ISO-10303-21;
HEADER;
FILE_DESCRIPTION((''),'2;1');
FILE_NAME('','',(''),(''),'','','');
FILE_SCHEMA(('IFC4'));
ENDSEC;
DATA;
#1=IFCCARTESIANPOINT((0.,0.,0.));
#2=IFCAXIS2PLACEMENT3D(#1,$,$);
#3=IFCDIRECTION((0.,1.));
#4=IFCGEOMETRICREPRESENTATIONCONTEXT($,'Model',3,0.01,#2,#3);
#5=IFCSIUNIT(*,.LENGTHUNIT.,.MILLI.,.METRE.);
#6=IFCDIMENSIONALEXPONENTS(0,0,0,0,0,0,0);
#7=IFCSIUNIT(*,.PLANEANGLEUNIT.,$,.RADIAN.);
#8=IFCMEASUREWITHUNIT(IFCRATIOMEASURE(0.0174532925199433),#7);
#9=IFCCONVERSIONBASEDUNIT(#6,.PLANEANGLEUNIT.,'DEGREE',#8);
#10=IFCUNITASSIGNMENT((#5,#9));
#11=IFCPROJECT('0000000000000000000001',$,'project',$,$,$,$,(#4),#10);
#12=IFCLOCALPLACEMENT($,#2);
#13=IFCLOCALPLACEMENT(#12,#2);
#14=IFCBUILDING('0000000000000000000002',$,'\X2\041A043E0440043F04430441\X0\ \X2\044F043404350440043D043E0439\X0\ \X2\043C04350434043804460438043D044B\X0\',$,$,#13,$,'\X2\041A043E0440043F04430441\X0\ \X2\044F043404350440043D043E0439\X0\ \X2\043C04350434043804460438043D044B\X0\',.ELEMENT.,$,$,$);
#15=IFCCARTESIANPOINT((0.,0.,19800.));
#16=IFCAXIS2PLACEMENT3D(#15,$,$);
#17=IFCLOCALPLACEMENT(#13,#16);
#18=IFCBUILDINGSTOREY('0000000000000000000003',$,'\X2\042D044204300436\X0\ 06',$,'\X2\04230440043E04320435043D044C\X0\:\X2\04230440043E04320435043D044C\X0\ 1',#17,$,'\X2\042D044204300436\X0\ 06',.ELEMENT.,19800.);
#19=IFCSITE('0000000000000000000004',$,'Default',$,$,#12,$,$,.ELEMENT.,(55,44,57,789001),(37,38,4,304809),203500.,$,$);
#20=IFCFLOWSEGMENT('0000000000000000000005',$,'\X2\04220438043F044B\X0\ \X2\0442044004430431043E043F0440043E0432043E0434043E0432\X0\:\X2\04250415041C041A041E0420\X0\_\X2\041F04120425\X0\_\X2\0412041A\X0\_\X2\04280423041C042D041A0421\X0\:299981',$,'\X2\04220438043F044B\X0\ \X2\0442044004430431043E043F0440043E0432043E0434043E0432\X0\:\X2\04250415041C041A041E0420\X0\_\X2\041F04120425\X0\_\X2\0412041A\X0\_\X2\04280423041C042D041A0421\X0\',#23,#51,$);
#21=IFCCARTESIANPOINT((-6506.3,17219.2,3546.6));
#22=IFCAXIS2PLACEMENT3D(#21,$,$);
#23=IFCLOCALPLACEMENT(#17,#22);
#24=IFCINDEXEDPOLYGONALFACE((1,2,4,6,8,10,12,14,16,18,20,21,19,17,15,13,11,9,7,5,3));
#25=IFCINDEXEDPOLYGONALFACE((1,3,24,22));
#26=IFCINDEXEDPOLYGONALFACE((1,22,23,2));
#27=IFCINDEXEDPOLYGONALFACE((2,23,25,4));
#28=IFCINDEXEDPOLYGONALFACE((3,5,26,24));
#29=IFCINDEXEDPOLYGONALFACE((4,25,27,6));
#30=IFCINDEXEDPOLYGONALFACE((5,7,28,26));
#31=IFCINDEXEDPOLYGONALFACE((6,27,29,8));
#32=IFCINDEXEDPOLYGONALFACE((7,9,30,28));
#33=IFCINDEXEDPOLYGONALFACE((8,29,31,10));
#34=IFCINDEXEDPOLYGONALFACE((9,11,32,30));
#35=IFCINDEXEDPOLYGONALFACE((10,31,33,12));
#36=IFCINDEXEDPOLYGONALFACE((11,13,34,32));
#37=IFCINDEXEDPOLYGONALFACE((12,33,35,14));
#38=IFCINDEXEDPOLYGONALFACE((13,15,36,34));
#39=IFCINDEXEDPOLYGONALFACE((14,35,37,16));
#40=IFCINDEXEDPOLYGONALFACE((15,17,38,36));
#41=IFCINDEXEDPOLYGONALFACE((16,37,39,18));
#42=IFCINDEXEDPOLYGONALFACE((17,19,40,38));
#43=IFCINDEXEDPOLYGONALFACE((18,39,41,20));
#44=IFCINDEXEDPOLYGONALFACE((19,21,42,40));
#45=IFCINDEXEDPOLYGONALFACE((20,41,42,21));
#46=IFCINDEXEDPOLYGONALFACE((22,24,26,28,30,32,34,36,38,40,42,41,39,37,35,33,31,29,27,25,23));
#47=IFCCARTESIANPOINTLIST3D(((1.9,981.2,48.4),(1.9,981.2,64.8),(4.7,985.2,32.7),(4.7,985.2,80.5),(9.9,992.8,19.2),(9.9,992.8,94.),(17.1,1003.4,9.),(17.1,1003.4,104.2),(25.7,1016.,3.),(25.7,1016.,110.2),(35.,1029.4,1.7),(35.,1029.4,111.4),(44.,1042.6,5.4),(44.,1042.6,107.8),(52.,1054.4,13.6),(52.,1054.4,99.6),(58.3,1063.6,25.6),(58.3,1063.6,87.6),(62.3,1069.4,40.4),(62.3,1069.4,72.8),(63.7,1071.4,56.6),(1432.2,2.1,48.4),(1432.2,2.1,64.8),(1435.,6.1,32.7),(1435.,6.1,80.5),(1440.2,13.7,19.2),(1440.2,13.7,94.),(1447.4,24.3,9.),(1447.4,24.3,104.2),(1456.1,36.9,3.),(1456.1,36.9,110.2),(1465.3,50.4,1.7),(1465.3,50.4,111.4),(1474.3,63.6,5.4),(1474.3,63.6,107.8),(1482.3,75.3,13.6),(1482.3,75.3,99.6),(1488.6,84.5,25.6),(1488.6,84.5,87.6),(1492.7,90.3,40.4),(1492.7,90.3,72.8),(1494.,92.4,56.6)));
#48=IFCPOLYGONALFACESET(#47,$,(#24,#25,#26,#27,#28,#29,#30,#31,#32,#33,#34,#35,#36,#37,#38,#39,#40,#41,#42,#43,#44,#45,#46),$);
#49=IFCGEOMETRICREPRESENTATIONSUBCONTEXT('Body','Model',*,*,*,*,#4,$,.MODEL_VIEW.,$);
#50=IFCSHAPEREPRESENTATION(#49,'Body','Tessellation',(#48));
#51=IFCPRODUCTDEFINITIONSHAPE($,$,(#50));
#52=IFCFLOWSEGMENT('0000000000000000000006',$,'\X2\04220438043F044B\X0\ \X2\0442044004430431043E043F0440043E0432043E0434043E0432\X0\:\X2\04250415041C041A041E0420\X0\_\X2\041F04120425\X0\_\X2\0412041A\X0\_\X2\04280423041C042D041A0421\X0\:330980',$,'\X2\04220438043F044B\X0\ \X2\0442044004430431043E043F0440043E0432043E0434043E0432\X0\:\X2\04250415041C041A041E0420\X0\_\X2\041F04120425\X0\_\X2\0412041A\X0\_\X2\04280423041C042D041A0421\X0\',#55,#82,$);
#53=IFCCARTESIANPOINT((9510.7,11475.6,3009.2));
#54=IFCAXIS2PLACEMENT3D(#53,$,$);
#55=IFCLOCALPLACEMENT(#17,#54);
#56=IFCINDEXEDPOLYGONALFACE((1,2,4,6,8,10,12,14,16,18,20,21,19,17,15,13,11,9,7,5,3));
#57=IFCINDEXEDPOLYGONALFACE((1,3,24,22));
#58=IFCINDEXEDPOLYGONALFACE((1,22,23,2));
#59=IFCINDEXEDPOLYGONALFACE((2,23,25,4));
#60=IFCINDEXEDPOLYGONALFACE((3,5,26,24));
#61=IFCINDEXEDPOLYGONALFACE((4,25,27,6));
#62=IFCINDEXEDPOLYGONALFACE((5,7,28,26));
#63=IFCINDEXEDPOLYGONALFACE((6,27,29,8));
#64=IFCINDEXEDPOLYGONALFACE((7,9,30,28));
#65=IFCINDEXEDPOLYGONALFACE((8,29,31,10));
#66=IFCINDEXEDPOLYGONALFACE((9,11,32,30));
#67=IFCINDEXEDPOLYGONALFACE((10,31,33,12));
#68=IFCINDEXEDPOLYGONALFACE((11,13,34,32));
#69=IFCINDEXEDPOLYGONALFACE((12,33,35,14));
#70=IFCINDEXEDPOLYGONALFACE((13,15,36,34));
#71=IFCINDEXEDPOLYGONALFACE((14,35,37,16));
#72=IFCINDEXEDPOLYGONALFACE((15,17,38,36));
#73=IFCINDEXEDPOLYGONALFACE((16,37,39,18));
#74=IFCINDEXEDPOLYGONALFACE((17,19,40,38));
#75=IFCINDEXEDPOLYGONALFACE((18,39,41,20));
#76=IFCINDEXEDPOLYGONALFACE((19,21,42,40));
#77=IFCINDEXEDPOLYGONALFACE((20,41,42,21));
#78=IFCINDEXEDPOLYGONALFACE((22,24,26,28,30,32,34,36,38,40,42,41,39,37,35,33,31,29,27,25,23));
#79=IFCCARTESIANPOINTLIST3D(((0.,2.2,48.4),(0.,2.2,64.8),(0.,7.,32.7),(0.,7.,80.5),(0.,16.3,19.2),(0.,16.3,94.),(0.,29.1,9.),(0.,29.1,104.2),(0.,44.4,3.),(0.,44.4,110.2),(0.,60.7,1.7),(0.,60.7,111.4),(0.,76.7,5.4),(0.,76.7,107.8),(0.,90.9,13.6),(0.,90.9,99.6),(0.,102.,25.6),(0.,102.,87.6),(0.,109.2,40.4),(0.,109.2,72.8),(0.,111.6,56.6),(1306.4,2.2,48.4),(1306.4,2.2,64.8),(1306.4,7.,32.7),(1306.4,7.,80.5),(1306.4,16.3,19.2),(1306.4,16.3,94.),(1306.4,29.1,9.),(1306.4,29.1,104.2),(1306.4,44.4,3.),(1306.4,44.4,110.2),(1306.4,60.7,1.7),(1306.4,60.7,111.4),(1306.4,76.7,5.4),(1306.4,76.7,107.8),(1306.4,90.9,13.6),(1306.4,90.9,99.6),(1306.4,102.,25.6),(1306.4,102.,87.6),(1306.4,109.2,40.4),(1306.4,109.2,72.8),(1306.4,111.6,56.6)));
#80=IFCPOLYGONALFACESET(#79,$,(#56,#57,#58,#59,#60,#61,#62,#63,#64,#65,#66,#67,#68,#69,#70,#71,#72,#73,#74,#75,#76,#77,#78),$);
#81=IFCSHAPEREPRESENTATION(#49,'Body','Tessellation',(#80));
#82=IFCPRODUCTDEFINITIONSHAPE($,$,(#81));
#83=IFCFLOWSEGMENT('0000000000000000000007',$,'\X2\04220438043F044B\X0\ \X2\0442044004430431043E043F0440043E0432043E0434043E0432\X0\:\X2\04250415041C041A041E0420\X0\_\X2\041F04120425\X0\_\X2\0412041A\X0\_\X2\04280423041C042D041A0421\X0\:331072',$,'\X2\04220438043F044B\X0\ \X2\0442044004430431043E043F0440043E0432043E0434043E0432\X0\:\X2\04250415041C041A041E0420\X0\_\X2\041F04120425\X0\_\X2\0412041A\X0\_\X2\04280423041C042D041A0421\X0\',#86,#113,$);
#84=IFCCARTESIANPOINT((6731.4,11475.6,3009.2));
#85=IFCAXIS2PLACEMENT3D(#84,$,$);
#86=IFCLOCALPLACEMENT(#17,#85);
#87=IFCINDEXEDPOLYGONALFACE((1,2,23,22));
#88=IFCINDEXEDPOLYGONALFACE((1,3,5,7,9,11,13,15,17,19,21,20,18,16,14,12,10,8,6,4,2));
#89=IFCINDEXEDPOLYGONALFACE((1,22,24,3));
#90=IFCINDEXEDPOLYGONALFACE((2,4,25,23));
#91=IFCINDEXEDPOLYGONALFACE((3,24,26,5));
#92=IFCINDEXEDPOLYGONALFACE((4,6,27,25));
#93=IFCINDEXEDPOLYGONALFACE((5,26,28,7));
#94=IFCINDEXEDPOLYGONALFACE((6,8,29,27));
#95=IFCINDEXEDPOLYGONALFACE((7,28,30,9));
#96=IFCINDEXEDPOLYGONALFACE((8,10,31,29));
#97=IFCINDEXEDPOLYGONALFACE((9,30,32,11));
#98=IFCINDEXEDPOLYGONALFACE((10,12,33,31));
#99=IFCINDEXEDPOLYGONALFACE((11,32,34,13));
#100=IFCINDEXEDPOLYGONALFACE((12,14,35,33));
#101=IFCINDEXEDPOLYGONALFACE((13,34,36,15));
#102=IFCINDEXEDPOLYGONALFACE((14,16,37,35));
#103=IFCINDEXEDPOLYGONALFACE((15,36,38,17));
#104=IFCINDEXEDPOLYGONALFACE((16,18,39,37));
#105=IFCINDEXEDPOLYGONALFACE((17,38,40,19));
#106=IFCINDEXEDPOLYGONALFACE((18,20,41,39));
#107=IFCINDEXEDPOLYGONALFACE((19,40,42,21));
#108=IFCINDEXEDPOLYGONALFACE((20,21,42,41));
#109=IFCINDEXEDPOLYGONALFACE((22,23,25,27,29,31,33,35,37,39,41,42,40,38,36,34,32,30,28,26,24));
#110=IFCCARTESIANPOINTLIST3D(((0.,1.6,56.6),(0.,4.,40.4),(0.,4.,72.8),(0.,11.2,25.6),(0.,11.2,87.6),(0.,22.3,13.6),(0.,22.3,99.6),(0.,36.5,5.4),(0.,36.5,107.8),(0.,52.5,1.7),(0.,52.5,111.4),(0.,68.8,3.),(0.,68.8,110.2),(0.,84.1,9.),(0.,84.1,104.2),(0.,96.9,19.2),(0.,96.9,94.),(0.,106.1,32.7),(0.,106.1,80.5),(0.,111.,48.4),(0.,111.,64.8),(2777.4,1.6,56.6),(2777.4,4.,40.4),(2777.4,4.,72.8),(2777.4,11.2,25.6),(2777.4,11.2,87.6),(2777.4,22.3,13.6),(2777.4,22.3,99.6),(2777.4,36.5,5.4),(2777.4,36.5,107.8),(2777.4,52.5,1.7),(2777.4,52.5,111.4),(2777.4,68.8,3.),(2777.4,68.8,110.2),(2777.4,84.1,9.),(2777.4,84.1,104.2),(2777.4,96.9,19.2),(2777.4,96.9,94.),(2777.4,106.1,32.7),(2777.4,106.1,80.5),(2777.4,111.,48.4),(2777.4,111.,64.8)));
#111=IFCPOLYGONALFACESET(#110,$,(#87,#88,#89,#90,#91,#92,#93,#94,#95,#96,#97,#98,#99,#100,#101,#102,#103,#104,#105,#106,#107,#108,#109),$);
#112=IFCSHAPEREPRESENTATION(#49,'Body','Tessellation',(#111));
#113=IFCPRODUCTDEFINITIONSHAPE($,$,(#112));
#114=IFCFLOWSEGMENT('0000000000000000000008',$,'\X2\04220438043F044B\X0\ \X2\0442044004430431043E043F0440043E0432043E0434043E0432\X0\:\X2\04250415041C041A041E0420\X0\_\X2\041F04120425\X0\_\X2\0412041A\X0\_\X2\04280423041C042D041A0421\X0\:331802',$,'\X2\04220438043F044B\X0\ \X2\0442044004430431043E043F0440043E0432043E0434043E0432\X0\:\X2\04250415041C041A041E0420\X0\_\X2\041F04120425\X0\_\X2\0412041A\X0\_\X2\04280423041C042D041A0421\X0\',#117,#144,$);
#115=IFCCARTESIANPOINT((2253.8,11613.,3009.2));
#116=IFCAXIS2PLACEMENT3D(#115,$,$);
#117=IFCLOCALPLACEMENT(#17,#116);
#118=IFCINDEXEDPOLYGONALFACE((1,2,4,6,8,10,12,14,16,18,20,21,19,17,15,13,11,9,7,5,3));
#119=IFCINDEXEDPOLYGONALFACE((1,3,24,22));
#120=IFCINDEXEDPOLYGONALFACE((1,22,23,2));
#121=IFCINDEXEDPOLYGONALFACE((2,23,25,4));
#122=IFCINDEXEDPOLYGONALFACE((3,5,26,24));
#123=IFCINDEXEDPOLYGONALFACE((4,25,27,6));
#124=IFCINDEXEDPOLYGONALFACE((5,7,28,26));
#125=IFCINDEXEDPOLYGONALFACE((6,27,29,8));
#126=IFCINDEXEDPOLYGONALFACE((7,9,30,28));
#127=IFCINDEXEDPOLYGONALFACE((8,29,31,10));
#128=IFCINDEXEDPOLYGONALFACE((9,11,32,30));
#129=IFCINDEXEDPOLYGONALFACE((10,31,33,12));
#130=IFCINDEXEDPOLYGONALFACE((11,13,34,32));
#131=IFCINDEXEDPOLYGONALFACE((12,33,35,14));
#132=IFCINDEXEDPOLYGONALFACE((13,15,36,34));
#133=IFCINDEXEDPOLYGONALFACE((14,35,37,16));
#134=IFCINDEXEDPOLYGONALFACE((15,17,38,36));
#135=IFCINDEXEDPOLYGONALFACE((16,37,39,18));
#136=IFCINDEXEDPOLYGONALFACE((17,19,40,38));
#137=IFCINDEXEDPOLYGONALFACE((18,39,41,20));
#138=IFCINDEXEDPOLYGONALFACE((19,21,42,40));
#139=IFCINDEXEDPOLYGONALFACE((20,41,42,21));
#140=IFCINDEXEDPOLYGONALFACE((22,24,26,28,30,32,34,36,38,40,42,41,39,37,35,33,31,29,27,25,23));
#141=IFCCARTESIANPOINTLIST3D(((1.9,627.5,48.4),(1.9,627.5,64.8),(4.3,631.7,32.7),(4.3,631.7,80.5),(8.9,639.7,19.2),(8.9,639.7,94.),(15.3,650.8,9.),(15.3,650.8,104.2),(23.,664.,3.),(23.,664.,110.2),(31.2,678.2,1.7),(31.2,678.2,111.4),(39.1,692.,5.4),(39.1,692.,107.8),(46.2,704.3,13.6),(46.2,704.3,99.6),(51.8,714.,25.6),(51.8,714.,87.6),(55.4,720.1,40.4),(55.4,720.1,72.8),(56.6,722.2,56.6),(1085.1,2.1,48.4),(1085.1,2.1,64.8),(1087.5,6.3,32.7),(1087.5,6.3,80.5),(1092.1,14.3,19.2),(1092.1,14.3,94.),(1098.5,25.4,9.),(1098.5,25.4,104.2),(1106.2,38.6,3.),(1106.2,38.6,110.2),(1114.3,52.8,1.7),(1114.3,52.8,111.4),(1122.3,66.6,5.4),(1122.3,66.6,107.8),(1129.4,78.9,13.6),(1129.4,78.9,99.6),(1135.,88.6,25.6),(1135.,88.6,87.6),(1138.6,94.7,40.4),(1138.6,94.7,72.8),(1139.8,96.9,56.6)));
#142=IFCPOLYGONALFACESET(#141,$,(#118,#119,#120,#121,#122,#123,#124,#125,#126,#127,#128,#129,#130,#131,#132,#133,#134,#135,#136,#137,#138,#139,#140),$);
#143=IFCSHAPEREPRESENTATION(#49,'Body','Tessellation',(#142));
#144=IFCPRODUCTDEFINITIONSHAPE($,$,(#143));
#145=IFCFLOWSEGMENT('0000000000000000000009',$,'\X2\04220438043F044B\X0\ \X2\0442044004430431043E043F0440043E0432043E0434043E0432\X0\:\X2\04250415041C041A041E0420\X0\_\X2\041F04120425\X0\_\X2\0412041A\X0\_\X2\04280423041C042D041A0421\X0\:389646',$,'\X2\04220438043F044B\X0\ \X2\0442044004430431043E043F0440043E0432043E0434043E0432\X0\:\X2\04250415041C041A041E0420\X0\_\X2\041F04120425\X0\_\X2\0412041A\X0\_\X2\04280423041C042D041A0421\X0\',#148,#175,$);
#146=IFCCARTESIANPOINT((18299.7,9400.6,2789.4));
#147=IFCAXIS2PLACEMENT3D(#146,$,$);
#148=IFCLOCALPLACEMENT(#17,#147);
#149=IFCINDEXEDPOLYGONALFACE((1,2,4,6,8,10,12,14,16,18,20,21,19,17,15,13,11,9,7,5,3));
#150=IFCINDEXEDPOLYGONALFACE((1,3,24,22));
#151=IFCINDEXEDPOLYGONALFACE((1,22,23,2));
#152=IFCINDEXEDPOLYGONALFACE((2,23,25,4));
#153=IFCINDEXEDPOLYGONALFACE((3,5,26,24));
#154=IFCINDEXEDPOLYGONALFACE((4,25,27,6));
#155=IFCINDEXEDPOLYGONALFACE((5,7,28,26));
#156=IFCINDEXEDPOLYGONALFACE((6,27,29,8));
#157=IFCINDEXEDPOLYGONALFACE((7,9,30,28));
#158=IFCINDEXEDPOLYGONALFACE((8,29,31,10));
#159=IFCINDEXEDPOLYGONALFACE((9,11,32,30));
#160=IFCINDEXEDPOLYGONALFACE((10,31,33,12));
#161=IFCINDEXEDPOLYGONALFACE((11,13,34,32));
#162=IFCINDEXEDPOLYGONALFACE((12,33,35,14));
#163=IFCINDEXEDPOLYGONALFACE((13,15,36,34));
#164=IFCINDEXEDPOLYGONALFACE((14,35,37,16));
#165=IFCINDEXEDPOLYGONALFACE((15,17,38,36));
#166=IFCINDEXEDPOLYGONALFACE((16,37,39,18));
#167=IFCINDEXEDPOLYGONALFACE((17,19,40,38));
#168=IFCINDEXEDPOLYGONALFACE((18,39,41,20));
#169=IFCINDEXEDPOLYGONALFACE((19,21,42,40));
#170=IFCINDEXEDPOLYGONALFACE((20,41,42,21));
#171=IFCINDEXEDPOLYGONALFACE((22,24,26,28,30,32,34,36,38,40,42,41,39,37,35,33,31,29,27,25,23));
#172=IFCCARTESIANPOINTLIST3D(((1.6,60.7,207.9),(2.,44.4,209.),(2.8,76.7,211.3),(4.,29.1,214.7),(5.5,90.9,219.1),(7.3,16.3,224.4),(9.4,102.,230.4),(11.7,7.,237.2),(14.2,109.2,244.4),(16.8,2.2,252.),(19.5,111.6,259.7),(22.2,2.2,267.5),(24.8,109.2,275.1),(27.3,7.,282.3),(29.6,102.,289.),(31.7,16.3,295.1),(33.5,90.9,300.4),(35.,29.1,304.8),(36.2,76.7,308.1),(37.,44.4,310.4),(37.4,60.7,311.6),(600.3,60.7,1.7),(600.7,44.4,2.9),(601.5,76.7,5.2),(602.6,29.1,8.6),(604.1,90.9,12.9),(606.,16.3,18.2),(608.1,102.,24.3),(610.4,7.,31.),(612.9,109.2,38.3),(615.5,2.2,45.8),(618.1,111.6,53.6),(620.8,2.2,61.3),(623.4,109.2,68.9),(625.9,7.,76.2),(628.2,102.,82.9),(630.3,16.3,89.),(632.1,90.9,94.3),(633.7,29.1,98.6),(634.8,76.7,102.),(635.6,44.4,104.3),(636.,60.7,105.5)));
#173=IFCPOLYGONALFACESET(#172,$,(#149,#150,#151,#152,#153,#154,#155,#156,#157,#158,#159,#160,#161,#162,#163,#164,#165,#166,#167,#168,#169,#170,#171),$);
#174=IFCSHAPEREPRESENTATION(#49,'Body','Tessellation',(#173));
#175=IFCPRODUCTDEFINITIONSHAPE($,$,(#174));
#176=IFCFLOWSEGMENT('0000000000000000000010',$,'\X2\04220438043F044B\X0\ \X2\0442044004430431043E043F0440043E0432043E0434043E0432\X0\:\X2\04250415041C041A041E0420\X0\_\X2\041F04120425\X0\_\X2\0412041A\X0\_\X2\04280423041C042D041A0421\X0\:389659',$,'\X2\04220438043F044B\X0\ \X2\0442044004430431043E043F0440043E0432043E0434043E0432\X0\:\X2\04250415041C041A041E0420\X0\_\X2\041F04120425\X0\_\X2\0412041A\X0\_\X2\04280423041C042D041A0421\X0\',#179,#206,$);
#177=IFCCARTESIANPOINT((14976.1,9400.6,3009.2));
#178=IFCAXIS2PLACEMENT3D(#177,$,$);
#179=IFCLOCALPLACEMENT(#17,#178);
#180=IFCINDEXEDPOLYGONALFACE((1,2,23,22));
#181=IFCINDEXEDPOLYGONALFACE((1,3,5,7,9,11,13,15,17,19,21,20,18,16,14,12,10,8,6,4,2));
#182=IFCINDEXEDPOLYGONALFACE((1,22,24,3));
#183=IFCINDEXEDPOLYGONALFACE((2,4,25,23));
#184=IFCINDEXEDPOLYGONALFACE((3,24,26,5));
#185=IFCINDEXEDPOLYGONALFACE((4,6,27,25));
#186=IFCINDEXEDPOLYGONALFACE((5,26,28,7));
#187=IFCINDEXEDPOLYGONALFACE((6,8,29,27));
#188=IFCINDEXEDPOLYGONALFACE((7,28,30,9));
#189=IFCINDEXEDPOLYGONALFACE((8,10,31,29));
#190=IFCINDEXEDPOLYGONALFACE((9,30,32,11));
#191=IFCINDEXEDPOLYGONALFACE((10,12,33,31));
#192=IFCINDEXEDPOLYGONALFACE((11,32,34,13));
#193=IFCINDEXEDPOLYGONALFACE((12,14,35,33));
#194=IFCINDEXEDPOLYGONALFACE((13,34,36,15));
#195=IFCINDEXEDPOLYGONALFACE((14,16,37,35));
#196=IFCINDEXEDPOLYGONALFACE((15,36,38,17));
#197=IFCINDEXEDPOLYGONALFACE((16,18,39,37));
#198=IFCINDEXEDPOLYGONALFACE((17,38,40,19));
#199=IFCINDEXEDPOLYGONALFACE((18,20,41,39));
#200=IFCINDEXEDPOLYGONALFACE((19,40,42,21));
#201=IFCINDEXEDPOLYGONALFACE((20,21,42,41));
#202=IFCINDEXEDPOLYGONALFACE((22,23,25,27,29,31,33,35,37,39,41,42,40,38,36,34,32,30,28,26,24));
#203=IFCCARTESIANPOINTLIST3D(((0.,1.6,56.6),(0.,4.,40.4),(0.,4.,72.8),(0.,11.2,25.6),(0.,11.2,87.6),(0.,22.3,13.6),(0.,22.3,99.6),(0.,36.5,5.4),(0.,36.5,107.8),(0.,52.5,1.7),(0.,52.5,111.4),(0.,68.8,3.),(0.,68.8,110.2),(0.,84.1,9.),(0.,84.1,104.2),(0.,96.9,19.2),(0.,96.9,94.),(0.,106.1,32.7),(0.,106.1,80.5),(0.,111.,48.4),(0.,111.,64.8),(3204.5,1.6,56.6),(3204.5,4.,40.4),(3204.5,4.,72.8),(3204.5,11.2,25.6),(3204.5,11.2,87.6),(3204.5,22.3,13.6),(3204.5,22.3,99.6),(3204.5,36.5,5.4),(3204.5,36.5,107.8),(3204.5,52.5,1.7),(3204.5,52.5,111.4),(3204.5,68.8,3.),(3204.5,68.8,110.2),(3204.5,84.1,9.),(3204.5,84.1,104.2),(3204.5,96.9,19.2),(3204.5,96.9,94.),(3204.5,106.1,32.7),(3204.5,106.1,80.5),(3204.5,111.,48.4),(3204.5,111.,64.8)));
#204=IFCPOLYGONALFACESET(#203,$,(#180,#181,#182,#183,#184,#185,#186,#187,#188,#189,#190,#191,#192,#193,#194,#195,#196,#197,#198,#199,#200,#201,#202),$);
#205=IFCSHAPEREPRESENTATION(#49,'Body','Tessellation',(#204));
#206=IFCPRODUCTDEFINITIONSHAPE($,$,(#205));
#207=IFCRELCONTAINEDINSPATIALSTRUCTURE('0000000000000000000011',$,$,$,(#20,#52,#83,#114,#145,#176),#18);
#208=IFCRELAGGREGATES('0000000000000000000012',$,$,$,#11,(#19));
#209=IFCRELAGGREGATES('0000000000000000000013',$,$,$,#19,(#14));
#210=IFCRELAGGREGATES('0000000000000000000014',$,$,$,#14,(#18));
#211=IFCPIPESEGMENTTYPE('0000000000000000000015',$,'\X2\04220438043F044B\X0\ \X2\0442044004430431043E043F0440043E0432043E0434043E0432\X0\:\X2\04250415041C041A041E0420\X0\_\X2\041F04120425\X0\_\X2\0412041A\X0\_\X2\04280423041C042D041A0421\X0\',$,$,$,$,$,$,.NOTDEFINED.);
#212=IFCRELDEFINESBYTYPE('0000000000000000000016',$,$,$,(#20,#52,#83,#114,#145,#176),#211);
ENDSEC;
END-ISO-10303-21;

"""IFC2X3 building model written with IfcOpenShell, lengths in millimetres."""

from ifc_helpers import new_model, entity, si_unit, converted_unit, direction, frame, origin, origin_2d_with_axis, place, context, subcontext, project, spatial, circle, extrude, type_object, element, save


model = new_model("IFC2X3")

# Units and contexts
model_context = context("Model", 3, precision=0.01, world=origin(), true_north=direction((0.0, 1.0)))
body_context = subcontext(model_context, "Body", "Model", "MODEL_VIEW")
ifc_project = project(units=[si_unit("LENGTHUNIT", "METRE", prefix="MILLI"), converted_unit("PLANEANGLEUNIT", "DEGREE", entity("IfcRatioMeasure", 0.0174532925199433), si_unit("PLANEANGLEUNIT", "RADIAN"), dimensions=[0, 0, 0, 0, 0, 0, 0])], contexts=[model_context])

# Site, building, storey
site_placement = place(None, frame((0.0, 0.0, 0.0)))
site = spatial("IfcSite", under=ifc_project, at=site_placement, Name="Default", CompositionType="ELEMENT", RefLatitude=(55, 44, 57, 789001), RefLongitude=(37, 38, 4, 304809), RefElevation=203500.0)
building_placement = place(site_placement, origin())
building = spatial("IfcBuilding", under=site, at=building_placement, Name="Корпус ядерной медицины", LongName="Корпус ядерной медицины", CompositionType="ELEMENT")
storey_placement = place(building_placement, frame((0.0, 0.0, 19800.0)))
storey = spatial("IfcBuildingStorey", under=building, at=storey_placement, Name="Этаж 06", ObjectType="Уровень:Уровень 1", LongName="Этаж 06", CompositionType="ELEMENT", Elevation=19800.0)

# Flow segments
pipe_segment_type = type_object("IfcPipeSegmentType", Name="Типы трубопроводов:ХЕМКОР_ПВХ_ВК_ШУМЭКС", PredefinedType="NOTDEFINED")
flow_segment_1_placement = place(storey_placement, frame((-6506.3, 17219.2, 3546.6)))
element("IfcFlowSegment", 1, at=flow_segment_1_placement, inside=storey, type_object=pipe_segment_type, Name="Типы трубопроводов:ХЕМКОР_ПВХ_ВК_ШУМЭКС:299981", ObjectType="Типы трубопроводов:ХЕМКОР_ПВХ_ВК_ШУМЭКС", context=body_context, shape_type="SweptSolid", body=[
    extrude(circle(Radius=55.0, at=origin_2d_with_axis()), frame((1463.0, 47.0, 56.6), z_axis=(-0.825187, 0.564859, 0.0), x_axis=(0.564859, 0.825187, 0.0)), (0.0, 0.0, 1.0), 1733.3),
])
flow_segment_2_placement = place(storey_placement, frame((9510.7, 11475.6, 3009.2)))
element("IfcFlowSegment", 2, at=flow_segment_2_placement, inside=storey, type_object=pipe_segment_type, Name="Типы трубопроводов:ХЕМКОР_ПВХ_ВК_ШУМЭКС:330980", ObjectType="Типы трубопроводов:ХЕМКОР_ПВХ_ВК_ШУМЭКС", context=body_context, shape_type="SweptSolid", body=[
    extrude(circle(Radius=55.0, at=origin_2d_with_axis()), frame((0.0, 56.6, 56.6), z_axis=(1.0, 0.0, 0.0), x_axis=(0.0, 1.0, 0.0)), (0.0, 0.0, 1.0), 1306.4),
])
flow_segment_3_placement = place(storey_placement, frame((6731.4, 11475.6, 3009.2)))
element("IfcFlowSegment", 3, at=flow_segment_3_placement, inside=storey, type_object=pipe_segment_type, Name="Типы трубопроводов:ХЕМКОР_ПВХ_ВК_ШУМЭКС:331072", ObjectType="Типы трубопроводов:ХЕМКОР_ПВХ_ВК_ШУМЭКС", context=body_context, shape_type="SweptSolid", body=[
    extrude(circle(Radius=55.0, at=origin_2d_with_axis()), frame((0.0, 56.6, 56.6), z_axis=(1.0, 0.0, 0.0), x_axis=(0.0, -1.0, 0.0)), (0.0, 0.0, 1.0), 2777.4),
])
flow_segment_4_placement = place(storey_placement, frame((2253.8, 11613.0, 3009.2)))
element("IfcFlowSegment", 4, at=flow_segment_4_placement, inside=storey, type_object=pipe_segment_type, Name="Типы трубопроводов:ХЕМКОР_ПВХ_ВК_ШУМЭКС:331802", ObjectType="Типы трубопроводов:ХЕМКОР_ПВХ_ВК_ШУМЭКС", context=body_context, shape_type="SweptSolid", body=[
    extrude(circle(Radius=55.0, at=origin_2d_with_axis()), frame((29.1, 674.6, 56.6), z_axis=(0.866025, -0.5, 0.0), x_axis=(0.5, 0.866025, 0.0)), (0.0, 0.0, 1.0), 1250.8),
])
flow_segment_5_placement = place(storey_placement, frame((18299.7, 9400.6, 2789.4)))
element("IfcFlowSegment", 5, at=flow_segment_5_placement, inside=storey, type_object=pipe_segment_type, Name="Типы трубопроводов:ХЕМКОР_ПВХ_ВК_ШУМЭКС:389646", ObjectType="Типы трубопроводов:ХЕМКОР_ПВХ_ВК_ШУМЭКС", context=body_context, shape_type="SweptSolid", body=[
    extrude(circle(Radius=55.0, at=origin_2d_with_axis()), frame((618.1, 56.6, 53.6), z_axis=(-0.945519, 0.0, 0.325568), x_axis=(0.0, 1.0, 0.0)), (0.0, 0.0, 1.0), 633.1),
])
flow_segment_6_placement = place(storey_placement, frame((14976.1, 9400.6, 3009.2)))
element("IfcFlowSegment", 6, at=flow_segment_6_placement, inside=storey, type_object=pipe_segment_type, Name="Типы трубопроводов:ХЕМКОР_ПВХ_ВК_ШУМЭКС:389659", ObjectType="Типы трубопроводов:ХЕМКОР_ПВХ_ВК_ШУМЭКС", context=body_context, shape_type="SweptSolid", body=[
    extrude(circle(Radius=55.0, at=origin_2d_with_axis()), frame((0.0, 56.6, 56.6), z_axis=(1.0, 0.0, 0.0), x_axis=(0.0, -1.0, 0.0)), (0.0, 0.0, 1.0), 3204.5),
])

save(model, "model.ifc")
